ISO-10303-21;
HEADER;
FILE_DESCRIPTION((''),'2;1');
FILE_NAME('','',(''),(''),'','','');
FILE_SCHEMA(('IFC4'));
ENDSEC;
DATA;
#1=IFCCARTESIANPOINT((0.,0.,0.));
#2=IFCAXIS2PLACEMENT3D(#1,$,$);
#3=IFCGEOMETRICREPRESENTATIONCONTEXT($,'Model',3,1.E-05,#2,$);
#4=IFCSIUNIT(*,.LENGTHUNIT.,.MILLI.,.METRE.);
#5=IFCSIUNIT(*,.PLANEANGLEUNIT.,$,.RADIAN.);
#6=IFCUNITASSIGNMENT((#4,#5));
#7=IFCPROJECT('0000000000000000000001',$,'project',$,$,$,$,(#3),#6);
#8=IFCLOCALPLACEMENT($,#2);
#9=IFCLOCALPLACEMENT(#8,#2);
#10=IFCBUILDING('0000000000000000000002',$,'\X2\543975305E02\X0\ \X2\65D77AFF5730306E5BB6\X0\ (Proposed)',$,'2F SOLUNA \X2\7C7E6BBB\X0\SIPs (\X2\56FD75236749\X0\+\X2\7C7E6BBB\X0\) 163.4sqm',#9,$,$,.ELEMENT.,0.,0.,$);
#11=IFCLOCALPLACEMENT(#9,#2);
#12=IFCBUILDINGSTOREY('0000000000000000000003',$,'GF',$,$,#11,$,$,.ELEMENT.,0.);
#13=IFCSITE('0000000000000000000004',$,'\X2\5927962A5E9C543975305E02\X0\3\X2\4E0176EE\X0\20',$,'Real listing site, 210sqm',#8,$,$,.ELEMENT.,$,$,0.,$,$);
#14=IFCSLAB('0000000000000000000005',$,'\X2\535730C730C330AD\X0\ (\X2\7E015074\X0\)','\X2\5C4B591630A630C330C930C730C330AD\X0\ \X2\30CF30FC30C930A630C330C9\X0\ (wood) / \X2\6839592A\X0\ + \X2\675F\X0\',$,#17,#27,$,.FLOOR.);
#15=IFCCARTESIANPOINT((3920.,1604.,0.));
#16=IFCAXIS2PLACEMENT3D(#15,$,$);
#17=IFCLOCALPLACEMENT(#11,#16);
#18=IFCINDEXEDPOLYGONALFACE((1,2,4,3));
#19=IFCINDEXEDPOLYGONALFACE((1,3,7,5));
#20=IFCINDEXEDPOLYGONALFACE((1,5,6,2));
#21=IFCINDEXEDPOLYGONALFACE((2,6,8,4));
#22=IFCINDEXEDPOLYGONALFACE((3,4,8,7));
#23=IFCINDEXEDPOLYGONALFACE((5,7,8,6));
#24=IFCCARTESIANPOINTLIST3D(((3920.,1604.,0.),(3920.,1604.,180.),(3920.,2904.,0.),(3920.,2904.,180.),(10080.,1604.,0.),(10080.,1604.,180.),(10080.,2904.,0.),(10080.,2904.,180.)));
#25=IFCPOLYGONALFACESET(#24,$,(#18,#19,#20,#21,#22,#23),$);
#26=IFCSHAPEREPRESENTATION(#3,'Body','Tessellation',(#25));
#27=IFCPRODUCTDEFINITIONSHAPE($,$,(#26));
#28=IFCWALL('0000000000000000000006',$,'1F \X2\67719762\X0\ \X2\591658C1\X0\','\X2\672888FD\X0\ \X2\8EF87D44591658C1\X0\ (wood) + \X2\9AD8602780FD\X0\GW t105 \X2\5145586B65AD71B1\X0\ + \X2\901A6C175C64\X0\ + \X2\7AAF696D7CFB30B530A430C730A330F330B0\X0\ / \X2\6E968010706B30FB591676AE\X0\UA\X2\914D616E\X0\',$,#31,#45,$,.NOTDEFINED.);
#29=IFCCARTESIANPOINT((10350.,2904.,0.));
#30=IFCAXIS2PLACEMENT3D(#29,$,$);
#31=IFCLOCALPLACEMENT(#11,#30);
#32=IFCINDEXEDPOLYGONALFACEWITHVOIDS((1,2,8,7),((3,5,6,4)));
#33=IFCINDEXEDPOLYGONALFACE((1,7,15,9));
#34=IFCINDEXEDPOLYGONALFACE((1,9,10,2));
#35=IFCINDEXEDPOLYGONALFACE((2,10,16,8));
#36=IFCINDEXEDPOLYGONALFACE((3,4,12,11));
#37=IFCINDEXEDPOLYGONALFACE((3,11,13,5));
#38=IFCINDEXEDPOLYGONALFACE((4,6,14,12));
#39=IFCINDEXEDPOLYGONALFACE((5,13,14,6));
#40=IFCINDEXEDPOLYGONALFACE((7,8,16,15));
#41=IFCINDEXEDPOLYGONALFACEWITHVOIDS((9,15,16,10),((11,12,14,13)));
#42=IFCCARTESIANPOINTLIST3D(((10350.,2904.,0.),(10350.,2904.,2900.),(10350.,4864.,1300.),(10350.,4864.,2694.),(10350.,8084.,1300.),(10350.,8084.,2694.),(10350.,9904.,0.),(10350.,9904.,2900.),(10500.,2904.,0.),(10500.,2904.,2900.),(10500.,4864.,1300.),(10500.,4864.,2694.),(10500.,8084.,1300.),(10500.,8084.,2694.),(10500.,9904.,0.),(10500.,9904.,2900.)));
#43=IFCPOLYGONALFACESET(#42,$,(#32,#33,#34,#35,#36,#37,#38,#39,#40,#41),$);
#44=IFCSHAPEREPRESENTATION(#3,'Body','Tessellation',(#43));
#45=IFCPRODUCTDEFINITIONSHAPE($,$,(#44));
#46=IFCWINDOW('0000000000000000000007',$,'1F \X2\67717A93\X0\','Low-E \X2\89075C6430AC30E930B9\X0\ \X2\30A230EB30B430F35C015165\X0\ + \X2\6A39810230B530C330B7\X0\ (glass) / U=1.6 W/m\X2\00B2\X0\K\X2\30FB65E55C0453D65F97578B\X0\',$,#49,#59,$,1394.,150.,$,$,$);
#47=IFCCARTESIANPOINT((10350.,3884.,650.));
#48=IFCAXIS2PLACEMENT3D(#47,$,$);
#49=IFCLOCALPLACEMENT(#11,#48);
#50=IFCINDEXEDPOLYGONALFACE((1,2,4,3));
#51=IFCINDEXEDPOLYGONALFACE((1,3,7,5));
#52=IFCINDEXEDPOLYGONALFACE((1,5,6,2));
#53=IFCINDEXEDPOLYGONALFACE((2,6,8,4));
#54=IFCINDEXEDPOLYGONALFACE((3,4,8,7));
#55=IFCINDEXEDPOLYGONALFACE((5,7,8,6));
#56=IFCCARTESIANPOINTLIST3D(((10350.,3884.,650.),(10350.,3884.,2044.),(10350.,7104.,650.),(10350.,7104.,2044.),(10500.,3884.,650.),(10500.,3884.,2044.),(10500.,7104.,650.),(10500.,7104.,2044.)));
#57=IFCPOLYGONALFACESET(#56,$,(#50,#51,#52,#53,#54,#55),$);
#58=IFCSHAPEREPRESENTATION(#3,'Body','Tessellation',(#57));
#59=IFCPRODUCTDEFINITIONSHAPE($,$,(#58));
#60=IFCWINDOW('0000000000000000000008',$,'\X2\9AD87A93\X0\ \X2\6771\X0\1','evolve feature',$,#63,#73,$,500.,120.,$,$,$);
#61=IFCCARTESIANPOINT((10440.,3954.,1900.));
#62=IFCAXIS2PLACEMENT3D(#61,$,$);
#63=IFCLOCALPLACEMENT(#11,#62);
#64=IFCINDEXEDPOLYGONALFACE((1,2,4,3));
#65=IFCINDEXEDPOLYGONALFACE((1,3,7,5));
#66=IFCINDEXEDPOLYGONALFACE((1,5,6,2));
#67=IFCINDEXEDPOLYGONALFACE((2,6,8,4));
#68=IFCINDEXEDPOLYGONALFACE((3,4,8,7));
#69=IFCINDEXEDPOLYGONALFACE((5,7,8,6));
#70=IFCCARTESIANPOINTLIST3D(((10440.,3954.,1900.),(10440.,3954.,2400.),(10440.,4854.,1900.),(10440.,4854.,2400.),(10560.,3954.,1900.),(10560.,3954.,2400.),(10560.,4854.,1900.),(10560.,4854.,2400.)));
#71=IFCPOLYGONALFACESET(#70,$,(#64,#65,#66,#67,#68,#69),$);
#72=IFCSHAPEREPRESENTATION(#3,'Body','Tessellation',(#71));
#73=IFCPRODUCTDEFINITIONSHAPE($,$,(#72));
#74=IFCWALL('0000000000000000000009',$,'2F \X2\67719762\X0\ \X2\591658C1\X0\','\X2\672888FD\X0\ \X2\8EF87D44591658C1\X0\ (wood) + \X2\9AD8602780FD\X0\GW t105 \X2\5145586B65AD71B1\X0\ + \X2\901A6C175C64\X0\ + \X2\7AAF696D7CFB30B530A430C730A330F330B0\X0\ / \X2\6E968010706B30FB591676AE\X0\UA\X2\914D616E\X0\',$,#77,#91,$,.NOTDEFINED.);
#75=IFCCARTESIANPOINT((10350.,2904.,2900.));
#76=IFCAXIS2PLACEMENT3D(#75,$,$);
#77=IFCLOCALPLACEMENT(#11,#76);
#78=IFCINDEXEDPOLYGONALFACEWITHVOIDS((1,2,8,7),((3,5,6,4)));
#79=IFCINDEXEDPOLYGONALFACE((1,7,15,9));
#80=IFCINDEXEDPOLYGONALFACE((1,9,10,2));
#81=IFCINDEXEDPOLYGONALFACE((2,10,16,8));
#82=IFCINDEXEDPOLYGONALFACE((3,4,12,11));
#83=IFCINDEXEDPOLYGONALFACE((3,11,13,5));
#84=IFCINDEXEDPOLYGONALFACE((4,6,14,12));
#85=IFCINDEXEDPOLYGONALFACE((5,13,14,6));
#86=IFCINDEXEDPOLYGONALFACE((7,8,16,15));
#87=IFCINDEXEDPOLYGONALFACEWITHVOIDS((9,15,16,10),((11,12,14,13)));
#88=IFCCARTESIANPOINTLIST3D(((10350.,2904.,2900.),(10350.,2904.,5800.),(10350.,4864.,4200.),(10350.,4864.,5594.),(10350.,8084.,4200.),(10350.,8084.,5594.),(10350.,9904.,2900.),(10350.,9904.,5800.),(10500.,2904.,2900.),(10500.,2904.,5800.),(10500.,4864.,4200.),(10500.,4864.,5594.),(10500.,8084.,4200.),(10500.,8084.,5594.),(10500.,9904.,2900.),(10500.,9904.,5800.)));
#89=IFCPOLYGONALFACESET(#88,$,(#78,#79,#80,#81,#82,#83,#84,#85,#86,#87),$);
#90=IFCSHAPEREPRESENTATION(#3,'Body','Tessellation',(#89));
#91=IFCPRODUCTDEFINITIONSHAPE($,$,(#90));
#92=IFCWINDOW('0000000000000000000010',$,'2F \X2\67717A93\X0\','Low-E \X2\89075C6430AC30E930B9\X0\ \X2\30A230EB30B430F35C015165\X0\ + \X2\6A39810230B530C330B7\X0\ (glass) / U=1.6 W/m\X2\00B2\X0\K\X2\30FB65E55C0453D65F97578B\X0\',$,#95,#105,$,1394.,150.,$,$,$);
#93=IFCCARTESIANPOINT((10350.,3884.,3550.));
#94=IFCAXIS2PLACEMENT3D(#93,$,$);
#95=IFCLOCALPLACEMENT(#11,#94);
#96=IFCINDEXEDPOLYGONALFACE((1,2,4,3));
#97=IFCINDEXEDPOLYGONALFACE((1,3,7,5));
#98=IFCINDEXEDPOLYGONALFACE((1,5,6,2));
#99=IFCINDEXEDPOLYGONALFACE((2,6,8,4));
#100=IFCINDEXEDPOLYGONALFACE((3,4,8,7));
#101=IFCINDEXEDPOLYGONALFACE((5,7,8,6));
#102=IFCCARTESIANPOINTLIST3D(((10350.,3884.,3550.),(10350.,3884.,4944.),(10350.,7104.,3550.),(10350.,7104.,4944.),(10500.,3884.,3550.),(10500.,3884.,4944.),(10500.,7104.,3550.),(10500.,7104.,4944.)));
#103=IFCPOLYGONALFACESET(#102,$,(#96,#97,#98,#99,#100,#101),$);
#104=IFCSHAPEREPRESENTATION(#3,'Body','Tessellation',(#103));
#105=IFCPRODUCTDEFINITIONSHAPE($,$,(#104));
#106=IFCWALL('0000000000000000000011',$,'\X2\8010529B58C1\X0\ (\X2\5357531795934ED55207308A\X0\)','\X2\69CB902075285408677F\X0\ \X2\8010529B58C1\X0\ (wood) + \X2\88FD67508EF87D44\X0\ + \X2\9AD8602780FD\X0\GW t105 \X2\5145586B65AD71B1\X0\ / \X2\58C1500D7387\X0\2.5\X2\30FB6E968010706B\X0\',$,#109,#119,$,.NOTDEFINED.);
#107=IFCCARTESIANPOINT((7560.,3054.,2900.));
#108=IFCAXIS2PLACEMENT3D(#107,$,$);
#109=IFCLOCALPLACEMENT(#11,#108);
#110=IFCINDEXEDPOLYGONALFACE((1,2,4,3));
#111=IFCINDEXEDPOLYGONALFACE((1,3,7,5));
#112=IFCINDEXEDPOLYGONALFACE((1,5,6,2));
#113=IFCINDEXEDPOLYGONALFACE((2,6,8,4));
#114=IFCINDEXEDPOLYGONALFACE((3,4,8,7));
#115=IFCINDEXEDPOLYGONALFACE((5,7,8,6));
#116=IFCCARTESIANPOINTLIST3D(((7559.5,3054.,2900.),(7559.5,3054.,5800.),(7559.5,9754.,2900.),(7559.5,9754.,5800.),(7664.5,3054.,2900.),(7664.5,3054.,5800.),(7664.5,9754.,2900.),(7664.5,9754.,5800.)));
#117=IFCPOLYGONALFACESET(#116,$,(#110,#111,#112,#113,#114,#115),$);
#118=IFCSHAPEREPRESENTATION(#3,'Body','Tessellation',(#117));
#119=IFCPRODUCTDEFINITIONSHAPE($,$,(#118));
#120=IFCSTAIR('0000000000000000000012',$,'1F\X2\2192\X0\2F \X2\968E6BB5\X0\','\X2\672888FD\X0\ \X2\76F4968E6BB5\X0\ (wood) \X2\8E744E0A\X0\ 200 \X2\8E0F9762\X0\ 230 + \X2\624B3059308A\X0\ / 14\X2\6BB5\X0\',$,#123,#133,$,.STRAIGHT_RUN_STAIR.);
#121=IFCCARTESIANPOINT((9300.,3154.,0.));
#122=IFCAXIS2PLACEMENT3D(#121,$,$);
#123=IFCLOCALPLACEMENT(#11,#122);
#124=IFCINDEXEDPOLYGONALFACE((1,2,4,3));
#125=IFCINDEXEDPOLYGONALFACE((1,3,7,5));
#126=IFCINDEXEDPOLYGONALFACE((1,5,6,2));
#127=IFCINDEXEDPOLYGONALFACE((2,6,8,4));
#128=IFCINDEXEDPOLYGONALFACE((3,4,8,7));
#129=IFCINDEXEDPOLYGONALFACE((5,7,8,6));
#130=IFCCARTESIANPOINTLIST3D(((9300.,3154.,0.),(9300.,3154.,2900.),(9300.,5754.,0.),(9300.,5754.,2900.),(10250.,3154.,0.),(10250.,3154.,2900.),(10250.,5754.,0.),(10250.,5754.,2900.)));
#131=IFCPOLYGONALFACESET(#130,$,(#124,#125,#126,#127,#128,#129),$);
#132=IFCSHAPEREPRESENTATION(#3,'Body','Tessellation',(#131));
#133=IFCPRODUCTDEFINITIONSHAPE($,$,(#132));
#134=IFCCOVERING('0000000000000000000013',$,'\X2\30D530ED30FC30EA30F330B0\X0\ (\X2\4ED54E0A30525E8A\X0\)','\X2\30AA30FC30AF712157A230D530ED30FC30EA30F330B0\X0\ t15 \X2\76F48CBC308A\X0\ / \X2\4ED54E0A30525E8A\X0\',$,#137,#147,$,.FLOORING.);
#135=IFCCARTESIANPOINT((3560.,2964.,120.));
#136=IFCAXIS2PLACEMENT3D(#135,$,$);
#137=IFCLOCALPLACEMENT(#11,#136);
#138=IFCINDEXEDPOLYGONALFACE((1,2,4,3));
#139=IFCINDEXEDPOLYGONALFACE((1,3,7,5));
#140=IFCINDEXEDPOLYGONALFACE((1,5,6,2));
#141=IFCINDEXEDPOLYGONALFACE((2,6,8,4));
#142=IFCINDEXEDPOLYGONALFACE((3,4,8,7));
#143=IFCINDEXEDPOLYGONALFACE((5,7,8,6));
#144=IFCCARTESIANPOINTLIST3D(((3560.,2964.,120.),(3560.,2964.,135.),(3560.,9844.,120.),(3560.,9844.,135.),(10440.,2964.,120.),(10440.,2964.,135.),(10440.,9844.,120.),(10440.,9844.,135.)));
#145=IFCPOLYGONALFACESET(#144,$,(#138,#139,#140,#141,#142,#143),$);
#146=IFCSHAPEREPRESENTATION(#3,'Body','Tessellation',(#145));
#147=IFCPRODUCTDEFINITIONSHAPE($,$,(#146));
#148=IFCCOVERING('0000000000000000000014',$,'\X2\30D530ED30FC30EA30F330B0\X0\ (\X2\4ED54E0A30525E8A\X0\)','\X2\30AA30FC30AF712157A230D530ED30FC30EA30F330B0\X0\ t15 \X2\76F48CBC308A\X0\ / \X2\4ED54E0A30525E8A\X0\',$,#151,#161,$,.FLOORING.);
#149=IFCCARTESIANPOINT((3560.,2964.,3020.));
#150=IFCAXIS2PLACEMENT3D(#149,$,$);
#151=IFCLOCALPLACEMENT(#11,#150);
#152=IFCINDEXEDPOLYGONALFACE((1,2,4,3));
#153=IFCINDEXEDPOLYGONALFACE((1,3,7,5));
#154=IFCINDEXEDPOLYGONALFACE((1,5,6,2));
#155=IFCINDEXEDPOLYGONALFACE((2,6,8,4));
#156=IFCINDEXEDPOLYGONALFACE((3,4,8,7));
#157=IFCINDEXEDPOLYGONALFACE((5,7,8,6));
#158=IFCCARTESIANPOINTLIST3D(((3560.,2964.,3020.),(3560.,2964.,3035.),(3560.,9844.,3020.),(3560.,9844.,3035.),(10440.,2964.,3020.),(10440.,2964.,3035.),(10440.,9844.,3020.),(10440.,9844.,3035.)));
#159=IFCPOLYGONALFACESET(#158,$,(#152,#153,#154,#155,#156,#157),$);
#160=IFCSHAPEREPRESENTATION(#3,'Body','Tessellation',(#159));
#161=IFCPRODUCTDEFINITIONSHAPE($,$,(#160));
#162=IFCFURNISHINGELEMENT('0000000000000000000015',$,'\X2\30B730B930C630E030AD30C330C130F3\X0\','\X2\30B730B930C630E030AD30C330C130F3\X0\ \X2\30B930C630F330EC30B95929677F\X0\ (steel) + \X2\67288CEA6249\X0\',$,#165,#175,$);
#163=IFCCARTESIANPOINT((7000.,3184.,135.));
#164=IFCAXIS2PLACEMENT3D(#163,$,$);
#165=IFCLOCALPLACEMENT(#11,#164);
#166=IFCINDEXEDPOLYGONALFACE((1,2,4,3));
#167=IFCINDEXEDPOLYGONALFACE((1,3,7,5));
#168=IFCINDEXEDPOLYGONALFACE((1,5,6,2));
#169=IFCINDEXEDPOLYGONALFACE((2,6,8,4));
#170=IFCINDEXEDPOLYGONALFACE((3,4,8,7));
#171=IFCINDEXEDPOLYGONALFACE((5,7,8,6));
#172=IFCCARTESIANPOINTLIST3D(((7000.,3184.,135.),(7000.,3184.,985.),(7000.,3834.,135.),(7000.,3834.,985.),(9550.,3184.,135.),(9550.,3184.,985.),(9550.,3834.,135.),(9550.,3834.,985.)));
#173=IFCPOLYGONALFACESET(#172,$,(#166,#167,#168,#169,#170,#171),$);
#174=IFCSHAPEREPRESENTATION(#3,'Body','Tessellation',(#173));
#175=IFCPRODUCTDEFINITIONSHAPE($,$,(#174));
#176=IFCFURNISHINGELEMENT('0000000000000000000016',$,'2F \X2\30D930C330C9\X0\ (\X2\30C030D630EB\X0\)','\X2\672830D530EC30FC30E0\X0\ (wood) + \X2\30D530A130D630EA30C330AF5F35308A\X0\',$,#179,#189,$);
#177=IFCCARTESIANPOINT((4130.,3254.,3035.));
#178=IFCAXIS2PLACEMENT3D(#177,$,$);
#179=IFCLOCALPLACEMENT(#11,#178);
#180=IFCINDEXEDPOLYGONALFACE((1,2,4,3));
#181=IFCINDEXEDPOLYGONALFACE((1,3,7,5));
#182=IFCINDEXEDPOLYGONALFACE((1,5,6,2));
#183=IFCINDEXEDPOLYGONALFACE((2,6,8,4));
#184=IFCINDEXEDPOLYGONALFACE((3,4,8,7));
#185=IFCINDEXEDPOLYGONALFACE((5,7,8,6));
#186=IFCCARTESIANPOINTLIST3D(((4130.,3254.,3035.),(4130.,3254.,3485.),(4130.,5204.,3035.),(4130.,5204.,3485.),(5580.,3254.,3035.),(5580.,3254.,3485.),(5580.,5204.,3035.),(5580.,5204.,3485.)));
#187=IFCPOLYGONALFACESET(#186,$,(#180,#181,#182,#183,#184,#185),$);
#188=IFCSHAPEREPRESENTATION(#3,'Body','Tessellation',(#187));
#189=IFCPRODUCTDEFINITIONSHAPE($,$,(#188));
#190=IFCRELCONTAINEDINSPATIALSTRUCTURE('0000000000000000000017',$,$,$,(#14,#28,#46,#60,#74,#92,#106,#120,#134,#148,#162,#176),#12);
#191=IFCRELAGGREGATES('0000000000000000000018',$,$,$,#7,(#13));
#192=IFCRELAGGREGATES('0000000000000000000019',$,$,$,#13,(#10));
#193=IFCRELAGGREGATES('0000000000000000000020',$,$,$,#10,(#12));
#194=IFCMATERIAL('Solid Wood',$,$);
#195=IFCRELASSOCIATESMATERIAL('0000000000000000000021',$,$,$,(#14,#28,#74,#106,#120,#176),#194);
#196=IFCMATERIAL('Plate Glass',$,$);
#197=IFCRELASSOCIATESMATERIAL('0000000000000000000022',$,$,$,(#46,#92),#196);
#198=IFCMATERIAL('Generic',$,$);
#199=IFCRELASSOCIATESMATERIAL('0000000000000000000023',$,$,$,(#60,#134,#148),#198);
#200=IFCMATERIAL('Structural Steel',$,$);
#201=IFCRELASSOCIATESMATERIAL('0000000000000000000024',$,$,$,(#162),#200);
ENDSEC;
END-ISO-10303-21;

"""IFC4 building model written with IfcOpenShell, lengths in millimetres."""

from ifc_helpers import new_model, si_unit, frame, frame_2d, origin, place, context, project, spatial, rectangle, extrude, material, element, fill, save


model = new_model("IFC4")

# Units and contexts
model_context = context("Model", 3, precision=1e-05, world=origin())
ifc_project = project(units=[si_unit("LENGTHUNIT", "METRE", prefix="MILLI"), si_unit("PLANEANGLEUNIT", "RADIAN")], contexts=[model_context])

# Site, building, storey
site_placement = place(None, origin())
site = spatial("IfcSite", under=ifc_project, at=site_placement, Name="大阪府吹田市3丁目20", ObjectType="Real listing site, 210sqm", CompositionType="ELEMENT", RefElevation=0.0)
building_placement = place(site_placement, origin())
building = spatial("IfcBuilding", under=site, at=building_placement, Name="吹田市 旗竿地の家 (Proposed)", ObjectType="2F SOLUNA 籾殻SIPs (国産杉+籾殻) 163.4sqm", CompositionType="ELEMENT", ElevationOfRefHeight=0.0, ElevationOfTerrain=0.0)
storey_placement = place(building_placement, origin())
storey = spatial("IfcBuildingStorey", under=building, at=storey_placement, Name="GF", CompositionType="ELEMENT", Elevation=0.0)

# Slab
ifc_material_1 = material(Name="Solid Wood")
slab_placement = place(storey_placement, frame((3920.0, 1604.0, 0.0)))
element("IfcSlab", 1, at=slab_placement, inside=storey, material=ifc_material_1, Name="南デッキ (縁側)", Description="屋外ウッドデッキ ハードウッド (wood) / 根太 + 束", PredefinedType="FLOOR", context=model_context, shape_type="SweptSolid", body=[
    extrude(rectangle(XDim=6160.0, YDim=1300.0, at=frame_2d((3080.0, 650.0))), frame((3920.0, 1604.0, 0.0)), (0.0, 0.0, 1.0), 180.0),
])

# Wall, openings, windows
wall_1_placement = place(storey_placement, frame((10350.0, 2904.0, 0.0)))
wall_1 = element("IfcWall", 2, at=wall_1_placement, inside=storey, material=ifc_material_1, Name="1F 東面 外壁", Description="木製 軸組外壁 (wood) + 高性能GW t105 充填断熱 + 通気層 + 窯業系サイディング / 準耐火・外皮UA配慮", PredefinedType="NOTDEFINED", context=model_context, shape_type="SweptSolid", body=[
    extrude(rectangle(XDim=150.0, YDim=7000.0, at=frame_2d((75.0, 3500.0))), frame((10350.0, 2904.0, 0.0)), (0.0, 0.0, 1.0), 2900.0),
])
opening_1_placement = place(storey_placement, frame((10350.0, 3884.0, 650.0)))
opening_1 = element("IfcOpeningElement", 3, at=opening_1_placement, cuts=wall_1, PredefinedType="NOTDEFINED", context=model_context, shape_type="SweptSolid", body=[
    extrude(rectangle(XDim=150.0, YDim=3220.0, at=frame_2d((75.0, 1610.0))), frame((10350.0, 3884.0, 650.0)), (0.0, 0.0, 1.0), 1394.0),
])
opening_2_placement = place(storey_placement, frame((10440.0, 3954.0, 1900.0)))
opening_2 = element("IfcOpeningElement", 4, at=opening_2_placement, cuts=wall_1, PredefinedType="NOTDEFINED", context=model_context, shape_type="SweptSolid", body=[
    extrude(rectangle(XDim=120.0, YDim=900.0, at=frame_2d((60.0, 450.0))), frame((10440.0, 3954.0, 1900.0)), (0.0, 0.0, 1.0), 500.0),
])
ifc_material_2 = material(Name="Plate Glass")
window_1_placement = place(storey_placement, frame((10350.0, 3884.0, 650.0)))
window_1 = element("IfcWindow", 5, at=window_1_placement, inside=storey, material=ifc_material_2, Name="1F 東窓", Description="Low-E 複層ガラス アルゴン封入 + 樹脂サッシ (glass) / U=1.6 W/m²K・日射取得型", OverallHeight=1394.0, OverallWidth=150.0, context=model_context, shape_type="SweptSolid", body=[
    extrude(rectangle(XDim=150.0, YDim=3220.0, at=frame_2d((75.0, 1610.0))), frame((10350.0, 3884.0, 650.0)), (0.0, 0.0, 1.0), 1394.0),
])
fill(opening_1, window_1)
ifc_material_3 = material(Name="Generic")
window_2_placement = place(storey_placement, frame((10440.0, 3954.0, 1900.0)))
window_2 = element("IfcWindow", 6, at=window_2_placement, inside=storey, material=ifc_material_3, Name="高窓 東1", Description="evolve feature", OverallHeight=500.0, OverallWidth=120.0, context=model_context, shape_type="SweptSolid", body=[
    extrude(rectangle(XDim=120.0, YDim=900.0, at=frame_2d((60.0, 450.0))), frame((10440.0, 3954.0, 1900.0)), (0.0, 0.0, 1.0), 500.0),
])
fill(opening_2, window_2)

# Wall, opening, window
wall_2_placement = place(storey_placement, frame((10350.0, 2904.0, 2900.0)))
wall_2 = element("IfcWall", 7, at=wall_2_placement, inside=storey, material=ifc_material_1, Name="2F 東面 外壁", Description="木製 軸組外壁 (wood) + 高性能GW t105 充填断熱 + 通気層 + 窯業系サイディング / 準耐火・外皮UA配慮", PredefinedType="NOTDEFINED", context=model_context, shape_type="SweptSolid", body=[
    extrude(rectangle(XDim=150.0, YDim=7000.0, at=frame_2d((75.0, 3500.0))), frame((10350.0, 2904.0, 2900.0)), (0.0, 0.0, 1.0), 2900.0),
])
opening_3_placement = place(storey_placement, frame((10350.0, 3884.0, 3550.0)))
opening_3 = element("IfcOpeningElement", 8, at=opening_3_placement, cuts=wall_2, PredefinedType="NOTDEFINED", context=model_context, shape_type="SweptSolid", body=[
    extrude(rectangle(XDim=150.0, YDim=3220.0, at=frame_2d((75.0, 1610.0))), frame((10350.0, 3884.0, 3550.0)), (0.0, 0.0, 1.0), 1394.0),
])
window_3_placement = place(storey_placement, frame((10350.0, 3884.0, 3550.0)))
window_3 = element("IfcWindow", 9, at=window_3_placement, inside=storey, material=ifc_material_2, Name="2F 東窓", Description="Low-E 複層ガラス アルゴン封入 + 樹脂サッシ (glass) / U=1.6 W/m²K・日射取得型", OverallHeight=1394.0, OverallWidth=150.0, context=model_context, shape_type="SweptSolid", body=[
    extrude(rectangle(XDim=150.0, YDim=3220.0, at=frame_2d((75.0, 1610.0))), frame((10350.0, 3884.0, 3550.0)), (0.0, 0.0, 1.0), 1394.0),
])
fill(opening_3, window_3)

# Wall
wall_3_placement = place(storey_placement, frame((7560.0, 3054.0, 2900.0)))
element("IfcWall", 10, at=wall_3_placement, inside=storey, material=ifc_material_1, Name="耐力壁 (南北間仕切り)", Description="構造用合板 耐力壁 (wood) + 製材軸組 + 高性能GW t105 充填断熱 / 壁倍率2.5・準耐火", PredefinedType="NOTDEFINED", context=model_context, shape_type="SweptSolid", body=[
    extrude(rectangle(XDim=105.0, YDim=6700.0, at=frame_2d((52.0, 3350.0))), frame((7560.0, 3054.0, 2900.0)), (0.0, 0.0, 1.0), 2900.0),
])

# Stair
stair_placement = place(storey_placement, frame((9300.0, 3154.0, 0.0)))
element("IfcStair", 11, at=stair_placement, inside=storey, material=ifc_material_1, Name="1F→2F 階段", Description="木製 直階段 (wood) 蹴上 200 踏面 230 + 手すり / 14段", PredefinedType="STRAIGHT_RUN_STAIR", context=model_context, shape_type="SweptSolid", body=[
    extrude(rectangle(XDim=950.0, YDim=2600.0, at=frame_2d((475.0, 1300.0))), frame((9300.0, 3154.0, 0.0)), (0.0, 0.0, 1.0), 2900.0),
])

# Coverings
covering_1_placement = place(storey_placement, frame((3560.0, 2964.0, 120.0)))
element("IfcCovering", 12, at=covering_1_placement, inside=storey, material=ifc_material_3, Name="フローリング (仕上げ床)", Description="オーク無垢フローリング t15 直貼り / 仕上げ床", PredefinedType="FLOORING", context=model_context, shape_type="SweptSolid", body=[
    extrude(rectangle(XDim=6880.0, YDim=6880.0, at=frame_2d((3440.0, 3440.0))), frame((3560.0, 2964.0, 120.0)), (0.0, 0.0, 1.0), 15.0),
])
covering_2_placement = place(storey_placement, frame((3560.0, 2964.0, 3020.0)))
element("IfcCovering", 13, at=covering_2_placement, inside=storey, material=ifc_material_3, Name="フローリング (仕上げ床)", Description="オーク無垢フローリング t15 直貼り / 仕上げ床", PredefinedType="FLOORING", context=model_context, shape_type="SweptSolid", body=[
    extrude(rectangle(XDim=6880.0, YDim=6880.0, at=frame_2d((3440.0, 3440.0))), frame((3560.0, 2964.0, 3020.0)), (0.0, 0.0, 1.0), 15.0),
])

# Furnishing elements
ifc_material_4 = material(Name="Structural Steel")
furnishing_1_placement = place(storey_placement, frame((7000.0, 3184.0, 135.0)))
element("IfcFurnishingElement", 14, at=furnishing_1_placement, inside=storey, material=ifc_material_4, Name="システムキッチン", Description="システムキッチン ステンレス天板 (steel) + 木質扉", context=model_context, shape_type="SweptSolid", body=[
    extrude(rectangle(XDim=2550.0, YDim=650.0, at=frame_2d((1275.0, 325.0))), frame((7000.0, 3184.0, 135.0)), (0.0, 0.0, 1.0), 850.0),
])
furnishing_2_placement = place(storey_placement, frame((4130.0, 3254.0, 3035.0)))
element("IfcFurnishingElement", 15, at=furnishing_2_placement, inside=storey, material=ifc_material_1, Name="2F ベッド (ダブル)", Description="木フレーム (wood) + ファブリック張り", context=model_context, shape_type="SweptSolid", body=[
    extrude(rectangle(XDim=1450.0, YDim=1950.0, at=frame_2d((725.0, 975.0))), frame((4130.0, 3254.0, 3035.0)), (0.0, 0.0, 1.0), 450.0),
])

save(model, "model.ifc")
